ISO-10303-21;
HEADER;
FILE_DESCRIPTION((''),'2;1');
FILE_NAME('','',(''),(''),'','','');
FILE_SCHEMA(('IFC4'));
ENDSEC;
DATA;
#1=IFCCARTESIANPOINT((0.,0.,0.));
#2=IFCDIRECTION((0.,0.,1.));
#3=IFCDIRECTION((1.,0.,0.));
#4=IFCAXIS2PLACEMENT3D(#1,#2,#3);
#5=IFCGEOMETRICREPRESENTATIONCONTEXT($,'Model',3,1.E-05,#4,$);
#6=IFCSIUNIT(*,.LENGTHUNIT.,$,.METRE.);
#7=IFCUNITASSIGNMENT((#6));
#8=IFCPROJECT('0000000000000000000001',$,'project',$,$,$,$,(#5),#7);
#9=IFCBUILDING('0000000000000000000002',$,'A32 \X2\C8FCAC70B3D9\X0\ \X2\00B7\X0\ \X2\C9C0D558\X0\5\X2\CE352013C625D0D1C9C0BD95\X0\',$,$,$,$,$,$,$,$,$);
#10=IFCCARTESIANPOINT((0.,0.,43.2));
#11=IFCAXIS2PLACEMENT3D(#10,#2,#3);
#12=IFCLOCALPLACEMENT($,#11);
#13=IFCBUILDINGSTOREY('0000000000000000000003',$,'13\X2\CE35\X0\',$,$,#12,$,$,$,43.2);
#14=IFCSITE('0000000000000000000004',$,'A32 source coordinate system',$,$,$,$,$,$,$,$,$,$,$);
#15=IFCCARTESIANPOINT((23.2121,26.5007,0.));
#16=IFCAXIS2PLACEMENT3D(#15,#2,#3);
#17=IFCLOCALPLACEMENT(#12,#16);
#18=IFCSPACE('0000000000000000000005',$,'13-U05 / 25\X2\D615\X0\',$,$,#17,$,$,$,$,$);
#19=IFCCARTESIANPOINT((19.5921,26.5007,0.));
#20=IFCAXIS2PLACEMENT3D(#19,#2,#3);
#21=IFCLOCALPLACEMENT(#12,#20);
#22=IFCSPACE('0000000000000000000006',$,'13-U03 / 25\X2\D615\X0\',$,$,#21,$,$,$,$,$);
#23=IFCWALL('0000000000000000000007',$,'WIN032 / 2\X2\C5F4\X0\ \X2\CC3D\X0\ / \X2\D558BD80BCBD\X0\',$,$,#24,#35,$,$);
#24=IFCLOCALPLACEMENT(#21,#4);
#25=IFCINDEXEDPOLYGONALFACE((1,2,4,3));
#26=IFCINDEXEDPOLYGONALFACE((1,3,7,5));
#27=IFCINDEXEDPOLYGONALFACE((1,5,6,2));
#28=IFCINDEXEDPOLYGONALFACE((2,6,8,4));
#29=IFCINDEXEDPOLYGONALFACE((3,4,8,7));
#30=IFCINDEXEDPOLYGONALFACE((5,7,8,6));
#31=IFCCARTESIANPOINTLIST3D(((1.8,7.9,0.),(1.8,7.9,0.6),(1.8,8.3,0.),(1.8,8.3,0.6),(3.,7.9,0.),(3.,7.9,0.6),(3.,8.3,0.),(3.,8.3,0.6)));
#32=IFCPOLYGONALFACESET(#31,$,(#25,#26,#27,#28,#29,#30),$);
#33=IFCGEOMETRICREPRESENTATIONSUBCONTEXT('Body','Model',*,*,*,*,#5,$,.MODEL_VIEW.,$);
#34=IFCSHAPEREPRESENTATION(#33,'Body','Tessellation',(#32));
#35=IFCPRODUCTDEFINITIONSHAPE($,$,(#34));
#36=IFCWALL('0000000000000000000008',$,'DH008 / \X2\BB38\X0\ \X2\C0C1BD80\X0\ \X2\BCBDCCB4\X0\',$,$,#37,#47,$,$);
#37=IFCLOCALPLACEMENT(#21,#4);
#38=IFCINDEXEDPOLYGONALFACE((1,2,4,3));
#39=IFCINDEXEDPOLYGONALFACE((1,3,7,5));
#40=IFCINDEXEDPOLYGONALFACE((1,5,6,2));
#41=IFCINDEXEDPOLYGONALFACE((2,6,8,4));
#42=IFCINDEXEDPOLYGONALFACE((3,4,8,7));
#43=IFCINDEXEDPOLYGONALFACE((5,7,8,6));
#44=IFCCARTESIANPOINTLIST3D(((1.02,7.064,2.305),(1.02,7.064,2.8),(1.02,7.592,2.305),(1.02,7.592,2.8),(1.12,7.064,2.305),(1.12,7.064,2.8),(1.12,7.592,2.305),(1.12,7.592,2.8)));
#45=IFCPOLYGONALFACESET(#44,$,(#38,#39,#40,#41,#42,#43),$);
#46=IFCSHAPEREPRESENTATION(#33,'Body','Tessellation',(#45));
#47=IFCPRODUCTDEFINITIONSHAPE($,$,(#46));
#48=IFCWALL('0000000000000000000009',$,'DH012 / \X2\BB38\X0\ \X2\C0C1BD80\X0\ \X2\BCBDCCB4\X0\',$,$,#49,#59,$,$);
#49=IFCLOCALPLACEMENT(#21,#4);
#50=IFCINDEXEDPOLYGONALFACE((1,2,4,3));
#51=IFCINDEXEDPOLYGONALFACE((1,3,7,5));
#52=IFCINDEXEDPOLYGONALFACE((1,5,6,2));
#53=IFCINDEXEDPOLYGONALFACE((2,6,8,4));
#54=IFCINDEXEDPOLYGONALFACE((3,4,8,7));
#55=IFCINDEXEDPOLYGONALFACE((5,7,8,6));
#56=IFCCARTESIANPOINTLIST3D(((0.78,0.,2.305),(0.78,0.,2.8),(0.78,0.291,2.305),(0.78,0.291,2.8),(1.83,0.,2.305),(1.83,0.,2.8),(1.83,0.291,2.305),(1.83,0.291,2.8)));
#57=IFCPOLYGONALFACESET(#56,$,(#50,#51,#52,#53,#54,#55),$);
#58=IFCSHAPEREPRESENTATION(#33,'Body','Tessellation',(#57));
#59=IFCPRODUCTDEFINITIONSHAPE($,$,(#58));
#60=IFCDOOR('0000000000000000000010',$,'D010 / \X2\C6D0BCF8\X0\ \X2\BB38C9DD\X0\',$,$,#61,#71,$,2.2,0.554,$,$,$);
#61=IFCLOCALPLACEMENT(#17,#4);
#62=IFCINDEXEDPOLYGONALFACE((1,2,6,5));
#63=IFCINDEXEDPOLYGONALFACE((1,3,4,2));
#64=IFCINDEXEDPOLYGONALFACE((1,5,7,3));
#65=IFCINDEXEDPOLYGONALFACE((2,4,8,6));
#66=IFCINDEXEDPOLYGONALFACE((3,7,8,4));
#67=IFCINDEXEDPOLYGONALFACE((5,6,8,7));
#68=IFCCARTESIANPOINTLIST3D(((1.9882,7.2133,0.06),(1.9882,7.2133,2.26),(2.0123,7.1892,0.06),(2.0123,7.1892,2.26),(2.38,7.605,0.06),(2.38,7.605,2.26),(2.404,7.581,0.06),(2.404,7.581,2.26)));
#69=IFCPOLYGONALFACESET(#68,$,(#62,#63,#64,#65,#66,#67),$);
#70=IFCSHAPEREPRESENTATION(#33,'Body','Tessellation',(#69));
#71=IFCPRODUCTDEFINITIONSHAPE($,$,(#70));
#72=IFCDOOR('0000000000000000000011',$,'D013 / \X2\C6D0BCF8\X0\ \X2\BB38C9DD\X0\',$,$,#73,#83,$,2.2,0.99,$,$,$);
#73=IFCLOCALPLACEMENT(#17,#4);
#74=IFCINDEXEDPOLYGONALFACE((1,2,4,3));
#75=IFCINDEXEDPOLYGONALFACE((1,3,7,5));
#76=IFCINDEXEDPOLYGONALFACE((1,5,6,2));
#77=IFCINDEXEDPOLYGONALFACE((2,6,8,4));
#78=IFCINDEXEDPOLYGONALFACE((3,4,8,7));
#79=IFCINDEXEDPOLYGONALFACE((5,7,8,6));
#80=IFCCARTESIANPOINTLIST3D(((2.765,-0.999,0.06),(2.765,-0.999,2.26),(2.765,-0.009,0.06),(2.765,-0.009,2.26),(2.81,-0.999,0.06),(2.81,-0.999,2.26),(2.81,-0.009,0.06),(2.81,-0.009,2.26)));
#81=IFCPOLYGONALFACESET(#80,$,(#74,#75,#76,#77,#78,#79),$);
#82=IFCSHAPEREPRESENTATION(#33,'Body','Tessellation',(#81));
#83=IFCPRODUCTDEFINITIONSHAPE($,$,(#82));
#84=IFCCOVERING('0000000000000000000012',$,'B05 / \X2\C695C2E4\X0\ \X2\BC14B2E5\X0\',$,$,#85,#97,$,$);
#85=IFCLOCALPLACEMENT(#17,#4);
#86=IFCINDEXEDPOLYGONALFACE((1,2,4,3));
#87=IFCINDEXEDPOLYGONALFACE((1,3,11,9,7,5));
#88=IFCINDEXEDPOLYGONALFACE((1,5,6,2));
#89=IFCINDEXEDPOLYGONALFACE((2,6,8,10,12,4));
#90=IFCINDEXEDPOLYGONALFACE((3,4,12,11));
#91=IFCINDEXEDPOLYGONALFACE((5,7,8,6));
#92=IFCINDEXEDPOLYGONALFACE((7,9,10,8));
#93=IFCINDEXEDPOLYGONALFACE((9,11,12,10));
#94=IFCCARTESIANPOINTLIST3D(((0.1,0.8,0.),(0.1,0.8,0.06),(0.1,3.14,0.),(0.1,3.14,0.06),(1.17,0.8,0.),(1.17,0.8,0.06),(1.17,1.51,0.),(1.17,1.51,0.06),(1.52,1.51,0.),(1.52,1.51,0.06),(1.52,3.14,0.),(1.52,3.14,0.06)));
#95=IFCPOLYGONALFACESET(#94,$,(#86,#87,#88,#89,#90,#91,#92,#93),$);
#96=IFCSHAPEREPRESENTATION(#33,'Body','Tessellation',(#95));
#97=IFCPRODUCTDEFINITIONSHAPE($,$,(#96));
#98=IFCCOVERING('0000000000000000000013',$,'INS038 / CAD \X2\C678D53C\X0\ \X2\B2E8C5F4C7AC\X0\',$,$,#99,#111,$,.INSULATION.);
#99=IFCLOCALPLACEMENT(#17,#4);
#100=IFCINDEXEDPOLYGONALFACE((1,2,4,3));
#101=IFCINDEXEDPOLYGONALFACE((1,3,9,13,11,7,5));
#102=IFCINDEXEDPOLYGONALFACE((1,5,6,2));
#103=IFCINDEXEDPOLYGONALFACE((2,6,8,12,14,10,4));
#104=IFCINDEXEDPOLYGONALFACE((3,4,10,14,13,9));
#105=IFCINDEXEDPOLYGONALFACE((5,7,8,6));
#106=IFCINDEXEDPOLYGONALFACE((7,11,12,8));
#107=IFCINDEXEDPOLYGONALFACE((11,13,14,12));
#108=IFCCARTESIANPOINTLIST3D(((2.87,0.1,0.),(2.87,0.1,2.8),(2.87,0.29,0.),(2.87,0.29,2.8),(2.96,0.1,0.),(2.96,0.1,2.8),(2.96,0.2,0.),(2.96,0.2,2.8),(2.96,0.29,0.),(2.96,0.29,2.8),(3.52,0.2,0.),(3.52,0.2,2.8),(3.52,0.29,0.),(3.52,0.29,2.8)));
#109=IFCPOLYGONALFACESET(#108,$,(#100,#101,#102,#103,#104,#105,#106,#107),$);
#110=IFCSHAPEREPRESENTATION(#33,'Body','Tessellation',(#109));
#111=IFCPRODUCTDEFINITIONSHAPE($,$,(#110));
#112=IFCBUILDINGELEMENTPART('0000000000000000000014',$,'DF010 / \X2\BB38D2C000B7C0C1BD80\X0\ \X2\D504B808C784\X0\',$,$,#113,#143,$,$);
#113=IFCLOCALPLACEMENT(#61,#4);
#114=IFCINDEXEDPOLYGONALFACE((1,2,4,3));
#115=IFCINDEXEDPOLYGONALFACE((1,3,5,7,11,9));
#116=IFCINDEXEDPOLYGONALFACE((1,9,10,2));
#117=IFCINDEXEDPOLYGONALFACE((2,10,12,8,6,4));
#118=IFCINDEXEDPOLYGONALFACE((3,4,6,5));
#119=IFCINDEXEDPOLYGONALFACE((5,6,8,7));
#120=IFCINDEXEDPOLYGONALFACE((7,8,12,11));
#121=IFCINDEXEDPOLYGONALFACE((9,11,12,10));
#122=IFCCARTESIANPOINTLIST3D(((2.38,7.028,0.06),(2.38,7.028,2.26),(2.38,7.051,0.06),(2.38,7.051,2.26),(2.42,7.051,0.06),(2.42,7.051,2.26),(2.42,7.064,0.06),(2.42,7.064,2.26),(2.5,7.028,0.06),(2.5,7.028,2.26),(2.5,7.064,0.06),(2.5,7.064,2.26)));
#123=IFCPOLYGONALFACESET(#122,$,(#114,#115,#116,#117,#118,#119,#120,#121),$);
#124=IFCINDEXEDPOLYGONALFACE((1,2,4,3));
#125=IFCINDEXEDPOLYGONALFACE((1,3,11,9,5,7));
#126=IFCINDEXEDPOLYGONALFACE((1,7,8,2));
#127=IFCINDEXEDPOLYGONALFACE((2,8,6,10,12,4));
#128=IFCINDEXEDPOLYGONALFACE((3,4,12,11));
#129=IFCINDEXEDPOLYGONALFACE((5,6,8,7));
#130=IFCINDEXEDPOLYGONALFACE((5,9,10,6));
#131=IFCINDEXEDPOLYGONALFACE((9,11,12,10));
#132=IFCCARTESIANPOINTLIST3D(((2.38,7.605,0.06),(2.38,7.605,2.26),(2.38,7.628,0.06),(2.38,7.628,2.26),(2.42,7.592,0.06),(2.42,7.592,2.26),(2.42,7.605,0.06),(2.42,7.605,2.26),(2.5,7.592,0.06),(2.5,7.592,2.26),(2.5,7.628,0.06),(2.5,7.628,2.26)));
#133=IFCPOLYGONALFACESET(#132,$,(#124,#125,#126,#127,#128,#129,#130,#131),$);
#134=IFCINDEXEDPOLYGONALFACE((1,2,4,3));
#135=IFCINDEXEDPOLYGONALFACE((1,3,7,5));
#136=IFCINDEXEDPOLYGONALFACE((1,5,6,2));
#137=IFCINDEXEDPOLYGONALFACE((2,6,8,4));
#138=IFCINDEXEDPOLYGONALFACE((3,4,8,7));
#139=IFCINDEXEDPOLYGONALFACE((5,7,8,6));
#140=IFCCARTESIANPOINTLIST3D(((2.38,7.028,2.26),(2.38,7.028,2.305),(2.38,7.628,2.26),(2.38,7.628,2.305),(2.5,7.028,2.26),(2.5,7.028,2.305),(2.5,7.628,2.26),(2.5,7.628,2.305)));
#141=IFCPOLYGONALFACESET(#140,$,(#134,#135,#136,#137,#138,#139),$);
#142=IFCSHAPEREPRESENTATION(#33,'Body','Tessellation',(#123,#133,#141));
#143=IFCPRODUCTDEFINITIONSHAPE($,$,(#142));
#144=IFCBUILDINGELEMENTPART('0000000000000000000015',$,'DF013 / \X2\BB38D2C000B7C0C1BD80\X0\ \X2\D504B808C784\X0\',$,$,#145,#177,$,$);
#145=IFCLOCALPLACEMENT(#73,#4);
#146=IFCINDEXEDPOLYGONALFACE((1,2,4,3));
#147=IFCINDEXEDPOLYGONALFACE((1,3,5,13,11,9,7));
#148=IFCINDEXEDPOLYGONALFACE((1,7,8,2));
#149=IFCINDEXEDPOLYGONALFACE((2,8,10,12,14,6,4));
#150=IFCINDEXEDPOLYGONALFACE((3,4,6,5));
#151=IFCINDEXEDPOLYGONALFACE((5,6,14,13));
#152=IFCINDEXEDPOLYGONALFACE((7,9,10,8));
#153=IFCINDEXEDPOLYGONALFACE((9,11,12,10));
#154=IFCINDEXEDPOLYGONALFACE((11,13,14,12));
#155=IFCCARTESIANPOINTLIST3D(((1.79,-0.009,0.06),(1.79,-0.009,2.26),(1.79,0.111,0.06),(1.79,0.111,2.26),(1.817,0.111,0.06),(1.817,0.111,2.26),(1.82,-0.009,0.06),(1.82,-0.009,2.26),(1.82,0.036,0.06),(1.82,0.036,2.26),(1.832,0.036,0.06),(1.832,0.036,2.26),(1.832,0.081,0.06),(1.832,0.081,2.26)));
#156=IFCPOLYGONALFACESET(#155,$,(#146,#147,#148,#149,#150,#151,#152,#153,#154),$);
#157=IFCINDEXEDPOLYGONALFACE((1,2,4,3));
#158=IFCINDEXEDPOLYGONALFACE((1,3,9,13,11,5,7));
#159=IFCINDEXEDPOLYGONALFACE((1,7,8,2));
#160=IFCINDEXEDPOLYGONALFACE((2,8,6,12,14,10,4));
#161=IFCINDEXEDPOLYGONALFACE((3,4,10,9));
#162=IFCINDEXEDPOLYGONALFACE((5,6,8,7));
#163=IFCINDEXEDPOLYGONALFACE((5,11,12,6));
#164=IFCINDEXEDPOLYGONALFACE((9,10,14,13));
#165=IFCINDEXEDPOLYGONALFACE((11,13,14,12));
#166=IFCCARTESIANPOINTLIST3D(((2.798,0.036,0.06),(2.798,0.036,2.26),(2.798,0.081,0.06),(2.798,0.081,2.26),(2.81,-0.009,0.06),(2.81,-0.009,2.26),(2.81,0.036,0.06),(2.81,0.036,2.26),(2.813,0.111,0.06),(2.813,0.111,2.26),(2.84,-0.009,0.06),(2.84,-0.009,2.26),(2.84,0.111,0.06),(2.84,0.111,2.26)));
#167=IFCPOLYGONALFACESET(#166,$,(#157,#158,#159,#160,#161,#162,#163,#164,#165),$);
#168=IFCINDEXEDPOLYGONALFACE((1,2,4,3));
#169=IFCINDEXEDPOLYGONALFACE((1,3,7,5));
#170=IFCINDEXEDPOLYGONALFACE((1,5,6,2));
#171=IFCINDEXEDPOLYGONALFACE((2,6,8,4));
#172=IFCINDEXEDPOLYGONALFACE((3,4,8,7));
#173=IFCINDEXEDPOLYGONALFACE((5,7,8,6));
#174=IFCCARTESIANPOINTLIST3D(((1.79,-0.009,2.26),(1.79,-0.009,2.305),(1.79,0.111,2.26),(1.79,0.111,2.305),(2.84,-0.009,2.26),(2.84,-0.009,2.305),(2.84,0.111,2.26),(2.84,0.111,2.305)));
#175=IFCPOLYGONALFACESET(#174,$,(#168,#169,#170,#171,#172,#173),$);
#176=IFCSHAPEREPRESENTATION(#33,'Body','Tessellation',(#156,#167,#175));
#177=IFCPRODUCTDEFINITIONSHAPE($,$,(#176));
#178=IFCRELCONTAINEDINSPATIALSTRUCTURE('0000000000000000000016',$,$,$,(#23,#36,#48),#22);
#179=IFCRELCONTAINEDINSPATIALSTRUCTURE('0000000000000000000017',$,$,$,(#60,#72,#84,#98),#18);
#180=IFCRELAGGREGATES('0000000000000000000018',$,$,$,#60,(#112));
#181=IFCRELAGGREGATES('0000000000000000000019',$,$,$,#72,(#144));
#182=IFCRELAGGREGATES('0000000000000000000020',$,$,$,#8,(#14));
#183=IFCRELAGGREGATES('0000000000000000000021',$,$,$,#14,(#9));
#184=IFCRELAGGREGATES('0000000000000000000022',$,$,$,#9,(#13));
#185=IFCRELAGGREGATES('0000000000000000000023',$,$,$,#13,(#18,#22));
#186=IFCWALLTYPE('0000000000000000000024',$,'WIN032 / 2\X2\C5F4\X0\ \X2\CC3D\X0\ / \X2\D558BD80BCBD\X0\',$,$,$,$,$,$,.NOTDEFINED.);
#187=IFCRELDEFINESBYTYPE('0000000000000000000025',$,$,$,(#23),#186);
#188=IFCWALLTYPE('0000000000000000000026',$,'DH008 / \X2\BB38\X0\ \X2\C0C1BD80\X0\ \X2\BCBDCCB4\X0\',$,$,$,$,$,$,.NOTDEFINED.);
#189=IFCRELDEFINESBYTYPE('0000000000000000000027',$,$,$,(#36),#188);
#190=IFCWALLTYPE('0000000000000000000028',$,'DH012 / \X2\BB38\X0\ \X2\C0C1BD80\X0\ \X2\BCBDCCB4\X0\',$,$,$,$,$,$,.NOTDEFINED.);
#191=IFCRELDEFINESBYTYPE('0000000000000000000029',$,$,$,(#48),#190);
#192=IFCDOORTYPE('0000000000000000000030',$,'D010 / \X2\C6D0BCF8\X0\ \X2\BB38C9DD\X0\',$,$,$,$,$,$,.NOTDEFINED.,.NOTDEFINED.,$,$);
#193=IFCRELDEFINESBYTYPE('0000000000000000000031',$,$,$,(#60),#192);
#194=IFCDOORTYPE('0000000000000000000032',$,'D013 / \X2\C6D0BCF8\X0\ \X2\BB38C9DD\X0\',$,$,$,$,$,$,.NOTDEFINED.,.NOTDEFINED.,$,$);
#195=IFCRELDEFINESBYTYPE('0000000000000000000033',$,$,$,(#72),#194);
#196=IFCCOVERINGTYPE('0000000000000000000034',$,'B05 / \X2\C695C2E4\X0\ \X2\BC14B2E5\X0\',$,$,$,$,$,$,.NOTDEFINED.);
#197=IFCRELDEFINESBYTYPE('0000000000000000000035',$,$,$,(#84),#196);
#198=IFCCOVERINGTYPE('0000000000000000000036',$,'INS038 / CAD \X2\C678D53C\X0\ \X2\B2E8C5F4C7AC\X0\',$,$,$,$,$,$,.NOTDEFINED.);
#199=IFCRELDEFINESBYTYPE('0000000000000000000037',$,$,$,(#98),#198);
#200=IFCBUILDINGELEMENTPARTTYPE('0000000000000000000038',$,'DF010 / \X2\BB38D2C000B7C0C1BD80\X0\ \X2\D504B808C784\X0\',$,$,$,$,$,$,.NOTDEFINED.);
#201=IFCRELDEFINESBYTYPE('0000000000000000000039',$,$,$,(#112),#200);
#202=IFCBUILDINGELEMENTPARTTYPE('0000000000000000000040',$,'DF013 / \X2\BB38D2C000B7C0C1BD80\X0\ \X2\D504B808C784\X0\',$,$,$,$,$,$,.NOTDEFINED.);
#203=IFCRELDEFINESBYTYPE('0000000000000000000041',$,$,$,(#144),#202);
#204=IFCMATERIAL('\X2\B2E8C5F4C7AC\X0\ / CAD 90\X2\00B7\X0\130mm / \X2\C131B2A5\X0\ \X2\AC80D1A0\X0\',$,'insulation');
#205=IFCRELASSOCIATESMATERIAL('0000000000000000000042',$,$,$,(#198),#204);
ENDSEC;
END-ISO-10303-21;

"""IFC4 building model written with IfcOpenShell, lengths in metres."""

from ifc_helpers import new_model, si_unit, frame, origin, origin_with_axes, place, context, subcontext, project, spatial, polyline, outline, extrude, source, transform, mapped, material, type_object, type_shapes, element, aggregate, save


model = new_model("IFC4")

# Units and contexts
model_context = context("Model", 3, precision=1e-05, world=origin_with_axes())
body_context = subcontext(model_context, "Body", "Model", "MODEL_VIEW")
ifc_project = project(units=[si_unit("LENGTHUNIT", "METRE")], contexts=[model_context])

# Site, building, storey, space
storey_placement = place(None, frame((0.0, 0.0, 43.2), z_axis=(0.0, 0.0, 1.0), x_axis=(1.0, 0.0, 0.0)))
space_1_placement = place(storey_placement, frame((23.2121, 26.5007, 0.0), z_axis=(0.0, 0.0, 1.0), x_axis=(1.0, 0.0, 0.0)))
site = spatial("IfcSite", under=ifc_project, Name="A32 source coordinate system")
building = spatial("IfcBuilding", under=site, Name="A32 주거동 · 지하5층–옥탑지붕")
storey = spatial("IfcBuildingStorey", under=building, at=storey_placement, Name="13층", Elevation=43.2)
space_1 = spatial("IfcSpace", under=storey, at=space_1_placement, Name="13-U05 / 25형")

# Shared definitions
space_2_placement = place(storey_placement, frame((19.5921, 26.5007, 0.0), z_axis=(0.0, 0.0, 1.0), x_axis=(1.0, 0.0, 0.0)))
space_2 = spatial("IfcSpace", under=storey, at=space_2_placement, Name="13-U03 / 25형")

# Walls
wall_type_1 = type_object("IfcWallType", Name="WIN032 / 2열 창 / 하부벽", PredefinedType="NOTDEFINED")
shared_shape_1 = source(origin(), body_context, "Body", "SweptSolid", [
    extrude(outline(polyline([(3.0, 7.9), (1.8, 7.9), (1.8, 8.3), (3.0, 8.3), (3.0, 7.9)])), origin(), (0.0, 0.0, 1.0), 0.6),
])
type_shapes(wall_type_1, [shared_shape_1])
wall_1_placement = place(space_2_placement, origin_with_axes())
element("IfcWall", 1, at=wall_1_placement, inside=space_2, type_object=wall_type_1, Name="WIN032 / 2열 창 / 하부벽", context=body_context, shape_type="MappedRepresentation", body=[
    mapped(shared_shape_1, transform((0.0, 0.0, 0.0), scale=1.0)),
])
wall_type_2 = type_object("IfcWallType", Name="DH008 / 문 상부 벽체", PredefinedType="NOTDEFINED")
shared_shape_2 = source(origin(), body_context, "Body", "SweptSolid", [
    extrude(outline(polyline([(1.12, 7.064), (1.02, 7.064), (1.02, 7.592), (1.12, 7.592), (1.12, 7.064)])), frame((0.0, 0.0, 2.305)), (0.0, 0.0, 1.0), 0.495),
])
type_shapes(wall_type_2, [shared_shape_2])
wall_2_placement = place(space_2_placement, origin_with_axes())
element("IfcWall", 2, at=wall_2_placement, inside=space_2, type_object=wall_type_2, Name="DH008 / 문 상부 벽체", context=body_context, shape_type="MappedRepresentation", body=[
    mapped(shared_shape_2, transform((0.0, 0.0, 0.0), scale=1.0)),
])
wall_type_3 = type_object("IfcWallType", Name="DH012 / 문 상부 벽체", PredefinedType="NOTDEFINED")
shared_shape_3 = source(origin(), body_context, "Body", "SweptSolid", [
    extrude(outline(polyline([(0.78, 0.0), (0.78, 0.291), (1.83, 0.291), (1.83, 0.0), (0.78, 0.0)])), frame((0.0, 0.0, 2.305)), (0.0, 0.0, 1.0), 0.495),
])
type_shapes(wall_type_3, [shared_shape_3])
wall_3_placement = place(space_2_placement, origin_with_axes())
element("IfcWall", 3, at=wall_3_placement, inside=space_2, type_object=wall_type_3, Name="DH012 / 문 상부 벽체", context=body_context, shape_type="MappedRepresentation", body=[
    mapped(shared_shape_3, transform((0.0, 0.0, 0.0), scale=1.0)),
])

# Doors
door_type_1 = type_object("IfcDoorType", Name="D010 / 원본 문짝", OperationType="NOTDEFINED", PredefinedType="NOTDEFINED")
shared_shape_4 = source(origin(), body_context, "Body", "SweptSolid", [
    extrude(outline(polyline([(2.0123, 7.1892), (1.9882, 7.2133), (2.38, 7.605), (2.404, 7.581), (2.0123, 7.1892)])), frame((0.0, 0.0, 0.06)), (0.0, 0.0, 1.0), 2.2),
])
type_shapes(door_type_1, [shared_shape_4])
door_1_placement = place(space_1_placement, origin_with_axes())
door_1 = element("IfcDoor", 4, at=door_1_placement, inside=space_1, type_object=door_type_1, Name="D010 / 원본 문짝", OverallHeight=2.2, OverallWidth=0.554, context=body_context, shape_type="MappedRepresentation", body=[
    mapped(shared_shape_4, transform((0.0, 0.0, 0.0), scale=1.0)),
])
door_type_2 = type_object("IfcDoorType", Name="D013 / 원본 문짝", OperationType="NOTDEFINED", PredefinedType="NOTDEFINED")
shared_shape_5 = source(origin(), body_context, "Body", "SweptSolid", [
    extrude(outline(polyline([(2.81, -0.009), (2.81, -0.999), (2.765, -0.999), (2.765, -0.009), (2.81, -0.009)])), frame((0.0, 0.0, 0.06)), (0.0, 0.0, 1.0), 2.2),
])
type_shapes(door_type_2, [shared_shape_5])
door_2_placement = place(space_1_placement, origin_with_axes())
door_2 = element("IfcDoor", 5, at=door_2_placement, inside=space_1, type_object=door_type_2, Name="D013 / 원본 문짝", OverallHeight=2.2, OverallWidth=0.99, context=body_context, shape_type="MappedRepresentation", body=[
    mapped(shared_shape_5, transform((0.0, 0.0, 0.0), scale=1.0)),
])

# Coverings
covering_type_1 = type_object("IfcCoveringType", Name="B05 / 욕실 바닥", PredefinedType="NOTDEFINED")
shared_shape_6 = source(origin(), body_context, "Body", "SweptSolid", [
    extrude(outline(polyline([(0.1, 3.14), (1.52, 3.14), (1.52, 1.51), (1.17, 1.51), (1.17, 0.8), (0.1, 0.8), (0.1, 3.14)])), origin(), (0.0, 0.0, 1.0), 0.06),
])
type_shapes(covering_type_1, [shared_shape_6])
covering_1_placement = place(space_1_placement, origin_with_axes())
element("IfcCovering", 6, at=covering_1_placement, inside=space_1, type_object=covering_type_1, Name="B05 / 욕실 바닥", context=body_context, shape_type="MappedRepresentation", body=[
    mapped(shared_shape_6, transform((0.0, 0.0, 0.0), scale=1.0)),
])
ifc_material = material(Name="단열재 / CAD 90·130mm / 성능 검토", Category="insulation")
covering_type_2 = type_object("IfcCoveringType", Name="INS038 / CAD 외피 단열재", PredefinedType="NOTDEFINED", material=ifc_material)
shared_shape_7 = source(origin(), body_context, "Body", "SweptSolid", [
    extrude(outline(polyline([(2.96, 0.2), (2.96, 0.1), (2.87, 0.1), (2.87, 0.29), (2.96, 0.29), (3.52, 0.29), (3.52, 0.2), (2.96, 0.2)])), origin(), (0.0, 0.0, 1.0), 2.8),
])
type_shapes(covering_type_2, [shared_shape_7])
covering_2_placement = place(space_1_placement, origin_with_axes())
element("IfcCovering", 7, at=covering_2_placement, inside=space_1, type_object=covering_type_2, Name="INS038 / CAD 외피 단열재", PredefinedType="INSULATION", context=body_context, shape_type="MappedRepresentation", body=[
    mapped(shared_shape_7, transform((0.0, 0.0, 0.0), scale=1.0)),
])

# Building element parts
building_element_part_type_1 = type_object("IfcBuildingElementPartType", Name="DF010 / 문틀·상부 프레임", PredefinedType="NOTDEFINED")
shared_shape_8 = source(origin(), body_context, "Body", "SweptSolid", [
    extrude(outline(polyline([(2.38, 7.028), (2.38, 7.051), (2.42, 7.051), (2.42, 7.064), (2.5, 7.064), (2.5, 7.028), (2.38, 7.028)])), frame((0.0, 0.0, 0.06)), (0.0, 0.0, 1.0), 2.2),
    extrude(outline(polyline([(2.5, 7.592), (2.42, 7.592), (2.42, 7.605), (2.38, 7.605), (2.38, 7.628), (2.5, 7.628), (2.5, 7.592)])), frame((0.0, 0.0, 0.06)), (0.0, 0.0, 1.0), 2.2),
    extrude(outline(polyline([(2.38, 7.028), (2.38, 7.628), (2.5, 7.628), (2.5, 7.028), (2.38, 7.028)])), frame((0.0, 0.0, 2.26)), (0.0, 0.0, 1.0), 0.045),
])
type_shapes(building_element_part_type_1, [shared_shape_8])
building_element_part_1_placement = place(door_1_placement, origin_with_axes())
building_element_part_1 = element("IfcBuildingElementPart", 8, at=building_element_part_1_placement, type_object=building_element_part_type_1, Name="DF010 / 문틀·상부 프레임", context=body_context, shape_type="MappedRepresentation", body=[
    mapped(shared_shape_8, transform((0.0, 0.0, 0.0), scale=1.0)),
])
aggregate(door_1, [building_element_part_1])
building_element_part_type_2 = type_object("IfcBuildingElementPartType", Name="DF013 / 문틀·상부 프레임", PredefinedType="NOTDEFINED")
shared_shape_9 = source(origin(), body_context, "Body", "SweptSolid", [
    extrude(outline(polyline([(1.79, 0.111), (1.817, 0.111), (1.832, 0.081), (1.832, 0.036), (1.82, 0.036), (1.82, -0.009), (1.79, -0.009), (1.79, 0.111)])), frame((0.0, 0.0, 0.06)), (0.0, 0.0, 1.0), 2.2),
    extrude(outline(polyline([(2.81, -0.009), (2.81, 0.036), (2.798, 0.036), (2.798, 0.081), (2.813, 0.111), (2.84, 0.111), (2.84, -0.009), (2.81, -0.009)])), frame((0.0, 0.0, 0.06)), (0.0, 0.0, 1.0), 2.2),
    extrude(outline(polyline([(1.79, -0.009), (1.79, 0.111), (2.84, 0.111), (2.84, -0.009), (1.79, -0.009)])), frame((0.0, 0.0, 2.26)), (0.0, 0.0, 1.0), 0.045),
])
type_shapes(building_element_part_type_2, [shared_shape_9])
building_element_part_2_placement = place(door_2_placement, origin_with_axes())
building_element_part_2 = element("IfcBuildingElementPart", 9, at=building_element_part_2_placement, type_object=building_element_part_type_2, Name="DF013 / 문틀·상부 프레임", context=body_context, shape_type="MappedRepresentation", body=[
    mapped(shared_shape_9, transform((0.0, 0.0, 0.0), scale=1.0)),
])
aggregate(door_2, [building_element_part_2])

save(model, "model.ifc")
